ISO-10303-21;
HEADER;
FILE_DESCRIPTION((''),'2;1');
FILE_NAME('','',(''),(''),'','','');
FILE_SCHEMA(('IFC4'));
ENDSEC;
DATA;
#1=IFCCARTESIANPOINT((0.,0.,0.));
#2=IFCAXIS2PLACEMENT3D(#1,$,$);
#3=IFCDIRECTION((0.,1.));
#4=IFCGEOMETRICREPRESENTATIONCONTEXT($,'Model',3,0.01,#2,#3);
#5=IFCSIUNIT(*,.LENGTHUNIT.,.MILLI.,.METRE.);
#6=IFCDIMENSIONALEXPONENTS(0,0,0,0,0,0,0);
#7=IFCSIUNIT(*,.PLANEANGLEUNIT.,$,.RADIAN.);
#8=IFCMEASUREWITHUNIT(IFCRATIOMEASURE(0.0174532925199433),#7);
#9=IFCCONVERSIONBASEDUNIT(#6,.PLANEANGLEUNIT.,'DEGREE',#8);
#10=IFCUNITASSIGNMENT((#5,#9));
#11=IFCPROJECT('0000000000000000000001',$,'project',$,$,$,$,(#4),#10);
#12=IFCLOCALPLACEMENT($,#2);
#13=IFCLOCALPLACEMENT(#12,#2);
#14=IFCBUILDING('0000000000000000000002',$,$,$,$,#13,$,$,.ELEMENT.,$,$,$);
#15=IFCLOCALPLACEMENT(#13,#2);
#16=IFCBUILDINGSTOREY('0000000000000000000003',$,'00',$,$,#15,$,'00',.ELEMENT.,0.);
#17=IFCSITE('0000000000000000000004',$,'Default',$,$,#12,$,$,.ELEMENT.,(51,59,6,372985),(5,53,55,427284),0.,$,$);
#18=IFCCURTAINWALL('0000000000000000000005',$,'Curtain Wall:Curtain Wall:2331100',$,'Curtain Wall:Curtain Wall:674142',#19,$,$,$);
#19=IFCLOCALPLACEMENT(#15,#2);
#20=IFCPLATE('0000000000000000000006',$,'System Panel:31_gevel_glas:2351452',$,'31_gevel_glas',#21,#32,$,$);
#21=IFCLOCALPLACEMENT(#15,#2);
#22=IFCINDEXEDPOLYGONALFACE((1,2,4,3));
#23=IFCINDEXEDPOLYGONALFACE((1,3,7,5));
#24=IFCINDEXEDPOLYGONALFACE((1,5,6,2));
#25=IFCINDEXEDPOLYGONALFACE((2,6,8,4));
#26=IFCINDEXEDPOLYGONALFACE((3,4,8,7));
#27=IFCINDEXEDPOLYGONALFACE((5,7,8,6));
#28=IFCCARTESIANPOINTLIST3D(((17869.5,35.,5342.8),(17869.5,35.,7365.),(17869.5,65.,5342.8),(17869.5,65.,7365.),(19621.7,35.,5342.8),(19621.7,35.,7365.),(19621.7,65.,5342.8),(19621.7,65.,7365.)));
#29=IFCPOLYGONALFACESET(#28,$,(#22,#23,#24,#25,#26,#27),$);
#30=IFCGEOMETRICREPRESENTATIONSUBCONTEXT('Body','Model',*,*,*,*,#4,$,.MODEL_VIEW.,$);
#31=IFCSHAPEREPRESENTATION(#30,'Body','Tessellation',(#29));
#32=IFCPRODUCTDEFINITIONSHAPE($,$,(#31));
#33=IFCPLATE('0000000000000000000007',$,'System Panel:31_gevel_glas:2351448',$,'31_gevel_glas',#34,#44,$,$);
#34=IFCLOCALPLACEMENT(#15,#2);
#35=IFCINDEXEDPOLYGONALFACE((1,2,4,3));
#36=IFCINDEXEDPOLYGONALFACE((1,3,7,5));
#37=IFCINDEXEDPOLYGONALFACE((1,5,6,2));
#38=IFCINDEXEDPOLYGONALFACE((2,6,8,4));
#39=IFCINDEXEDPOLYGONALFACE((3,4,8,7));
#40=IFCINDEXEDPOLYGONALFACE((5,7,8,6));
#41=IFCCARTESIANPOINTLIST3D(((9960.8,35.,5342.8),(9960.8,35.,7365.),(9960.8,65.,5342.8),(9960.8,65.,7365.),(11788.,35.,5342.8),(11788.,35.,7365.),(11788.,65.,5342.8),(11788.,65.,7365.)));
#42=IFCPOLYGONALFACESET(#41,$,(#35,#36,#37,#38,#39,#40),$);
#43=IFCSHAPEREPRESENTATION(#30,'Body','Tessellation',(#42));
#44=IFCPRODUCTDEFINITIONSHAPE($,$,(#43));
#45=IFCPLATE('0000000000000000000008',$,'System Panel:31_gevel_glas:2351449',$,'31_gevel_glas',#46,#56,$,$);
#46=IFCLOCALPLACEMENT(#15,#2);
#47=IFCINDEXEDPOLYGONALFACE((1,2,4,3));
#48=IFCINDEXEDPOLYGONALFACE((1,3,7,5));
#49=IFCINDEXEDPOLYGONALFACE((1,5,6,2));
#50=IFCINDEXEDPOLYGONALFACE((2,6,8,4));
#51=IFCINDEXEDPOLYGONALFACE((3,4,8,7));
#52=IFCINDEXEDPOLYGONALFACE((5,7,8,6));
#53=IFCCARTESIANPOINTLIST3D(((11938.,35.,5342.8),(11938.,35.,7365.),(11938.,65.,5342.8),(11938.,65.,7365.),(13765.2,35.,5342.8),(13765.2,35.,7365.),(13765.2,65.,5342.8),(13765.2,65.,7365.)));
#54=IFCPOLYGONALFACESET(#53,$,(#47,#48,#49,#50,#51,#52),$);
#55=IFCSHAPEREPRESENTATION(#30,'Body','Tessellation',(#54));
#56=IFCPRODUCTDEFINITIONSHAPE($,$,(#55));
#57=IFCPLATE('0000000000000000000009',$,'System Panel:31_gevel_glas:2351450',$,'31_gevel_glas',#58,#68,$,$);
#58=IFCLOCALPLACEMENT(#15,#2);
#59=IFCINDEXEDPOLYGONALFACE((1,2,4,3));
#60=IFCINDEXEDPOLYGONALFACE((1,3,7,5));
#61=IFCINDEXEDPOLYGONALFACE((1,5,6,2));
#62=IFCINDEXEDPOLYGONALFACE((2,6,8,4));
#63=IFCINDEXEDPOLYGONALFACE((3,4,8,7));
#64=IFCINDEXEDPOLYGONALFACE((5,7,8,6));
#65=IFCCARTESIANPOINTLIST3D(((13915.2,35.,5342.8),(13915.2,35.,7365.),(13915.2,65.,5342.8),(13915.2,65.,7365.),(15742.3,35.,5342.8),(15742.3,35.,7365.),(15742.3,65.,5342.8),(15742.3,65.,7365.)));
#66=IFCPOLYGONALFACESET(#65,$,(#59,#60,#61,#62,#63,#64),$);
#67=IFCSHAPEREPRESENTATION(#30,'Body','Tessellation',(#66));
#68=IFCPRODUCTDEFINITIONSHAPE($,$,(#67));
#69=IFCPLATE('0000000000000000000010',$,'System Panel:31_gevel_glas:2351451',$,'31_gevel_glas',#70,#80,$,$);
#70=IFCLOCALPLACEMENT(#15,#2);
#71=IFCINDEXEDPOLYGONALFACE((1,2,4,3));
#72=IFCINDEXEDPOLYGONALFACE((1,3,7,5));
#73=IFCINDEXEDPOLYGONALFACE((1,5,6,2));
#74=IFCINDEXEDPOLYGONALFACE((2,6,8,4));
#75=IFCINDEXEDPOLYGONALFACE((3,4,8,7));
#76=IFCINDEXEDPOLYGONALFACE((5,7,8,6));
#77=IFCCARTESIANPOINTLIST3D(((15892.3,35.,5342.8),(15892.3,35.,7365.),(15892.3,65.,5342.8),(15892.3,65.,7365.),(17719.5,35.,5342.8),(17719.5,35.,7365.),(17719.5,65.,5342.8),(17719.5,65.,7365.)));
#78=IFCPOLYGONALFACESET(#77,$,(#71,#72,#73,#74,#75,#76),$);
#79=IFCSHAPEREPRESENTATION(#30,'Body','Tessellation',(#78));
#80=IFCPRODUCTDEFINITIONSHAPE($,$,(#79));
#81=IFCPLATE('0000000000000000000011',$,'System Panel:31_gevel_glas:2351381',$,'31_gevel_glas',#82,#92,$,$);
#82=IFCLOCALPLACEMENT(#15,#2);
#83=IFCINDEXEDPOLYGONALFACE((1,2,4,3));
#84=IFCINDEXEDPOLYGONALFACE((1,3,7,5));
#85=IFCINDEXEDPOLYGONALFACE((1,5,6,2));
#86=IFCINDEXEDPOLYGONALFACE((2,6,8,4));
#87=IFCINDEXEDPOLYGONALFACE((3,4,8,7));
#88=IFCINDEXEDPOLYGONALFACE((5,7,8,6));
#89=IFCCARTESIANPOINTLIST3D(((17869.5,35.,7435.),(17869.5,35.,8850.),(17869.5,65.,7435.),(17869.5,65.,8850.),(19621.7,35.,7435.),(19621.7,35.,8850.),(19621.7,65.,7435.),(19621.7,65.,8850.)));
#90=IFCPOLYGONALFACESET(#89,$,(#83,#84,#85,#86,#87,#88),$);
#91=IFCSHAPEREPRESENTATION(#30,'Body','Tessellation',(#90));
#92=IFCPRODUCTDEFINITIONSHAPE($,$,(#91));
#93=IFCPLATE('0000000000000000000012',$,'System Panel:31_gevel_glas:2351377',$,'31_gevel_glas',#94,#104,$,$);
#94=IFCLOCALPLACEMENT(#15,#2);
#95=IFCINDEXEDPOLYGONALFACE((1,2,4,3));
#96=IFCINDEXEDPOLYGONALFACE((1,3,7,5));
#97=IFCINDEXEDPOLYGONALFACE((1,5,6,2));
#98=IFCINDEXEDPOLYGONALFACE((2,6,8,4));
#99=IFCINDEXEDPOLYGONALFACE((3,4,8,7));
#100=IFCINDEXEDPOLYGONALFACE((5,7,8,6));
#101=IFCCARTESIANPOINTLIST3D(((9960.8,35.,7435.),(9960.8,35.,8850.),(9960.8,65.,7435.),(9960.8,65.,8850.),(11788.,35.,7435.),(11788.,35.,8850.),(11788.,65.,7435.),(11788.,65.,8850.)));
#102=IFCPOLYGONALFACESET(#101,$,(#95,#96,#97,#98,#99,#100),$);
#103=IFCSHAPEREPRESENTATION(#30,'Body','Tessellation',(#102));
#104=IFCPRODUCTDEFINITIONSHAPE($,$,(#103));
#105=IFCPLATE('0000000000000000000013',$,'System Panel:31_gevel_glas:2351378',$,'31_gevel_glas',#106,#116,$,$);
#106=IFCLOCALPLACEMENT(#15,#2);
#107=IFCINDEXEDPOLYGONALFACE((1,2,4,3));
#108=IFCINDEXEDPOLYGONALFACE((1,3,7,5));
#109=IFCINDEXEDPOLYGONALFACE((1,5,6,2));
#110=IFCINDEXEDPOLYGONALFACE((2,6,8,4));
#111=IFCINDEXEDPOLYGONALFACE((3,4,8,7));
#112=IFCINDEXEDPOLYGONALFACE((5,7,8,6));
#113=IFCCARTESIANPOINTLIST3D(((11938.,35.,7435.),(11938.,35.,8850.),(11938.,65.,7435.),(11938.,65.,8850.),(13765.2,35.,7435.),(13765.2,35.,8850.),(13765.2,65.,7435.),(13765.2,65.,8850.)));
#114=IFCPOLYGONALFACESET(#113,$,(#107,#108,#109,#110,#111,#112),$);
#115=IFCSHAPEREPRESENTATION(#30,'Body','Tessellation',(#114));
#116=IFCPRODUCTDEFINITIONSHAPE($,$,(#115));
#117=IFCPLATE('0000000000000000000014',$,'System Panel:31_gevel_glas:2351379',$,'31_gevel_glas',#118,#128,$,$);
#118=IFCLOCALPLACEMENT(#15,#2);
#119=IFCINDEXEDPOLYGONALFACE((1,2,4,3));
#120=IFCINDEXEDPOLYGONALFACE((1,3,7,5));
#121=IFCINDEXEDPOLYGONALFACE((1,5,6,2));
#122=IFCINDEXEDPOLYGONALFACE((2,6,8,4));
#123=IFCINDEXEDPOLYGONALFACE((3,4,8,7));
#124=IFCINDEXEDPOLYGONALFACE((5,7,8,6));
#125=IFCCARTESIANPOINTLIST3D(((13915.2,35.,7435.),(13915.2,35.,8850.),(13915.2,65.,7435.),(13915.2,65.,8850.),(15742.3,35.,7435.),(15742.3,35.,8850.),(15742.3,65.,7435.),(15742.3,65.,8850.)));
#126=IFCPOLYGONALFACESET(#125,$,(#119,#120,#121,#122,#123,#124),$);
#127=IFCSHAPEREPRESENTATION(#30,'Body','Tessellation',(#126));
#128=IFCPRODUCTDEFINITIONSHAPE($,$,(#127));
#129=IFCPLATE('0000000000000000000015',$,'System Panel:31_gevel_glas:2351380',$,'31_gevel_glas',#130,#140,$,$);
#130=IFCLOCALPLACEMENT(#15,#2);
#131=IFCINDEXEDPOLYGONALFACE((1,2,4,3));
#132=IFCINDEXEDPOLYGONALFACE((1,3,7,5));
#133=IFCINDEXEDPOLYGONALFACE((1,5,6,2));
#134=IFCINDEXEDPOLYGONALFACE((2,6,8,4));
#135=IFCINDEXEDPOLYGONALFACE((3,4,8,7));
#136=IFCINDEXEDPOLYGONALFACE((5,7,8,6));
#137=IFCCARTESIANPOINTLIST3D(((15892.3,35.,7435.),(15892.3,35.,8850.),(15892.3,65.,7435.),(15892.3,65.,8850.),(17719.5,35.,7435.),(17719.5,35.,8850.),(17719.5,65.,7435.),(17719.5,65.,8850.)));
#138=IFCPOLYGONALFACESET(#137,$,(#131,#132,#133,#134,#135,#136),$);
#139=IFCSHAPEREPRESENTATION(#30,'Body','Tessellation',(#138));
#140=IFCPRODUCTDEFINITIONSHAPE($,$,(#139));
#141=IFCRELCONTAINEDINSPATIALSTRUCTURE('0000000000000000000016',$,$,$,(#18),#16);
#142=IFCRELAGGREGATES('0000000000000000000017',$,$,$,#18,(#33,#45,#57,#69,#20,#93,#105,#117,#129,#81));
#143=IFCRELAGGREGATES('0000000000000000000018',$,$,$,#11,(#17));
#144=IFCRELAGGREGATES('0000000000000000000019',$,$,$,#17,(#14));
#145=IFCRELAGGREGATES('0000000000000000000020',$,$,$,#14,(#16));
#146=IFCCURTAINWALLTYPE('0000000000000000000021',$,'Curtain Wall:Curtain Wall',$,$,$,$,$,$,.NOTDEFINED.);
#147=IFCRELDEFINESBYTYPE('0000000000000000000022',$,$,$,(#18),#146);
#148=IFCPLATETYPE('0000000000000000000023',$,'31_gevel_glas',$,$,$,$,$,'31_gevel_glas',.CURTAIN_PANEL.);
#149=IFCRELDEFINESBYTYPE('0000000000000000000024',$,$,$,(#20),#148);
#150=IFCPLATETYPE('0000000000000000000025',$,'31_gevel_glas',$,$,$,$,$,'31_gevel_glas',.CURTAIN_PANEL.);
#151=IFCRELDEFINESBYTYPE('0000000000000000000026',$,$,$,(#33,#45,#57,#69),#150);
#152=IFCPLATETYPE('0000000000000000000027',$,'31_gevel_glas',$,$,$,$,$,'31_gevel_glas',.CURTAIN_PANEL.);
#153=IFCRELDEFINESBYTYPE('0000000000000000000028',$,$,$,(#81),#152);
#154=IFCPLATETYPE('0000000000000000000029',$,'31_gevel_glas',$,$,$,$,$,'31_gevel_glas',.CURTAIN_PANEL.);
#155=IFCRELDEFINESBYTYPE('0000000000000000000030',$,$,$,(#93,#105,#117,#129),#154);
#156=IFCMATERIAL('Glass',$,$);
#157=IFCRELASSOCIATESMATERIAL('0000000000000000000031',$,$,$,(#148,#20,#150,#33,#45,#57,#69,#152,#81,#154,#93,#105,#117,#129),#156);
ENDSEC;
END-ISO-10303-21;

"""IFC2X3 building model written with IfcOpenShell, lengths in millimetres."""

from ifc_helpers import new_model, entity, si_unit, converted_unit, direction, frame, frame_2d, origin, origin_2d_with_axis, place, context, subcontext, project, spatial, rectangle, extrude, source, transform, mapped, material, type_object, type_shapes, element, aggregate, save


model = new_model("IFC2X3")

# Units and contexts
model_context = context("Model", 3, precision=0.01, world=origin(), true_north=direction((0.0, 1.0)))
body_context = subcontext(model_context, "Body", "Model", "MODEL_VIEW")
ifc_project = project(units=[si_unit("LENGTHUNIT", "METRE", prefix="MILLI"), converted_unit("PLANEANGLEUNIT", "DEGREE", entity("IfcRatioMeasure", 0.0174532925199433), si_unit("PLANEANGLEUNIT", "RADIAN"), dimensions=[0, 0, 0, 0, 0, 0, 0])], contexts=[model_context])

# Site, building, storey
site_placement = place(None, origin())
site = spatial("IfcSite", under=ifc_project, at=site_placement, Name="Default", CompositionType="ELEMENT", RefLatitude=(51, 59, 6, 372985), RefLongitude=(5, 53, 55, 427284), RefElevation=0.0)
building_placement = place(site_placement, origin())
building = spatial("IfcBuilding", under=site, at=building_placement, CompositionType="ELEMENT")
storey_placement = place(building_placement, origin())
storey = spatial("IfcBuildingStorey", under=building, at=storey_placement, Name="00", LongName="00", CompositionType="ELEMENT", Elevation=0.0)

# Curtain wall, plates
curtain_wall_type = type_object("IfcCurtainWallType", Name="Curtain Wall:Curtain Wall", PredefinedType="NOTDEFINED")
curtain_wall_placement = place(storey_placement, origin())
curtain_wall = element("IfcCurtainWall", 1, at=curtain_wall_placement, inside=storey, type_object=curtain_wall_type, Name="Curtain Wall:Curtain Wall:2331100", ObjectType="Curtain Wall:Curtain Wall:674142")
ifc_material = material(Name="Glass")
plate_type_1 = type_object("IfcPlateType", Name="31_gevel_glas", ElementType="31_gevel_glas", PredefinedType="CURTAIN_PANEL", material=ifc_material)
shared_shape_1 = source(origin(), body_context, "Body", "SweptSolid", [
    extrude(rectangle(XDim=30.0, YDim=1752.2, at=origin_2d_with_axis()), frame((0.0, 50.0, 0.0), z_axis=(0.0, 0.0, 1.0), x_axis=(0.0, 1.0, 0.0)), (0.0, 0.0, 1.0), 2022.2),
])
type_shapes(plate_type_1, [shared_shape_1])
plate_1_placement = place(curtain_wall_placement, frame((18745.6, 0.0, 5342.8)))
plate_1 = element("IfcPlate", 2, at=plate_1_placement, type_object=plate_type_1, material=ifc_material, Name="System Panel:31_gevel_glas:2351452", ObjectType="31_gevel_glas", context=body_context, shape_type="MappedRepresentation", body=[
    mapped(shared_shape_1, transform((0.0, 0.0, 0.0), scale=1.0)),
])
plate_type_2 = type_object("IfcPlateType", Name="31_gevel_glas", ElementType="31_gevel_glas", PredefinedType="CURTAIN_PANEL", material=ifc_material)
shared_shape_2 = source(origin(), body_context, "Body", "SweptSolid", [
    extrude(rectangle(XDim=30.0, YDim=1827.2, at=origin_2d_with_axis()), frame((0.0, 50.0, 0.0), z_axis=(0.0, 0.0, 1.0), x_axis=(0.0, 1.0, 0.0)), (0.0, 0.0, 1.0), 2022.2),
])
type_shapes(plate_type_2, [shared_shape_2])
plate_2_placement = place(curtain_wall_placement, frame((10874.4, 0.0, 5342.8)))
plate_2 = element("IfcPlate", 3, at=plate_2_placement, type_object=plate_type_2, material=ifc_material, Name="System Panel:31_gevel_glas:2351448", ObjectType="31_gevel_glas", context=body_context, shape_type="MappedRepresentation", body=[
    mapped(shared_shape_2, transform((0.0, 0.0, 0.0), scale=1.0)),
])
plate_3_placement = place(curtain_wall_placement, frame((12851.6, 0.0, 5342.8)))
plate_3 = element("IfcPlate", 4, at=plate_3_placement, type_object=plate_type_2, material=ifc_material, Name="System Panel:31_gevel_glas:2351449", ObjectType="31_gevel_glas", context=body_context, shape_type="MappedRepresentation", body=[
    mapped(shared_shape_2, transform((0.0, 0.0, 0.0), scale=1.0)),
])
plate_4_placement = place(curtain_wall_placement, frame((14828.8, 0.0, 5342.8)))
plate_4 = element("IfcPlate", 5, at=plate_4_placement, type_object=plate_type_2, material=ifc_material, Name="System Panel:31_gevel_glas:2351450", ObjectType="31_gevel_glas", context=body_context, shape_type="MappedRepresentation", body=[
    mapped(shared_shape_2, transform((0.0, 0.0, 0.0), scale=1.0)),
])
plate_5_placement = place(curtain_wall_placement, frame((16805.9, 0.0, 5342.8)))
plate_5 = element("IfcPlate", 6, at=plate_5_placement, type_object=plate_type_2, material=ifc_material, Name="System Panel:31_gevel_glas:2351451", ObjectType="31_gevel_glas", context=body_context, shape_type="MappedRepresentation", body=[
    mapped(shared_shape_2, transform((0.0, 0.0, 0.0), scale=1.0)),
])
plate_type_3 = type_object("IfcPlateType", Name="31_gevel_glas", ElementType="31_gevel_glas", PredefinedType="CURTAIN_PANEL", material=ifc_material)
shared_shape_3 = source(origin(), body_context, "Body", "SweptSolid", [
    extrude(rectangle(XDim=30.0, YDim=1752.2, at=frame_2d((0.0, 0.0), x_axis=(1.0, 0.0))), frame((0.0, 50.0, 0.0), z_axis=(0.0, 0.0, 1.0), x_axis=(0.0, 1.0, 0.0)), (0.0, 0.0, 1.0), 1415.0),
])
type_shapes(plate_type_3, [shared_shape_3])
plate_6_placement = place(curtain_wall_placement, frame((18745.6, 0.0, 7435.0)))
plate_6 = element("IfcPlate", 7, at=plate_6_placement, type_object=plate_type_3, material=ifc_material, Name="System Panel:31_gevel_glas:2351381", ObjectType="31_gevel_glas", context=body_context, shape_type="MappedRepresentation", body=[
    mapped(shared_shape_3, transform((0.0, 0.0, 0.0), scale=1.0)),
])
plate_type_4 = type_object("IfcPlateType", Name="31_gevel_glas", ElementType="31_gevel_glas", PredefinedType="CURTAIN_PANEL", material=ifc_material)
shared_shape_4 = source(origin(), body_context, "Body", "SweptSolid", [
    extrude(rectangle(XDim=30.0, YDim=1827.2, at=origin_2d_with_axis()), frame((0.0, 50.0, 0.0), z_axis=(0.0, 0.0, 1.0), x_axis=(0.0, 1.0, 0.0)), (0.0, 0.0, 1.0), 1415.0),
])
type_shapes(plate_type_4, [shared_shape_4])
plate_7_placement = place(curtain_wall_placement, frame((10874.4, 0.0, 7435.0)))
plate_7 = element("IfcPlate", 8, at=plate_7_placement, type_object=plate_type_4, material=ifc_material, Name="System Panel:31_gevel_glas:2351377", ObjectType="31_gevel_glas", context=body_context, shape_type="MappedRepresentation", body=[
    mapped(shared_shape_4, transform((0.0, 0.0, 0.0), scale=1.0)),
])
plate_8_placement = place(curtain_wall_placement, frame((12851.6, 0.0, 7435.0)))
plate_8 = element("IfcPlate", 9, at=plate_8_placement, type_object=plate_type_4, material=ifc_material, Name="System Panel:31_gevel_glas:2351378", ObjectType="31_gevel_glas", context=body_context, shape_type="MappedRepresentation", body=[
    mapped(shared_shape_4, transform((0.0, 0.0, 0.0), scale=1.0)),
])
plate_9_placement = place(curtain_wall_placement, frame((14828.8, 0.0, 7435.0)))
plate_9 = element("IfcPlate", 10, at=plate_9_placement, type_object=plate_type_4, material=ifc_material, Name="System Panel:31_gevel_glas:2351379", ObjectType="31_gevel_glas", context=body_context, shape_type="MappedRepresentation", body=[
    mapped(shared_shape_4, transform((0.0, 0.0, 0.0), scale=1.0)),
])
plate_10_placement = place(curtain_wall_placement, frame((16805.9, 0.0, 7435.0)))
plate_10 = element("IfcPlate", 11, at=plate_10_placement, type_object=plate_type_4, material=ifc_material, Name="System Panel:31_gevel_glas:2351380", ObjectType="31_gevel_glas", context=body_context, shape_type="MappedRepresentation", body=[
    mapped(shared_shape_4, transform((0.0, 0.0, 0.0), scale=1.0)),
])
aggregate(curtain_wall, [plate_2, plate_3, plate_4, plate_5, plate_1, plate_7, plate_8, plate_9, plate_10, plate_6])

save(model, "model.ifc")
